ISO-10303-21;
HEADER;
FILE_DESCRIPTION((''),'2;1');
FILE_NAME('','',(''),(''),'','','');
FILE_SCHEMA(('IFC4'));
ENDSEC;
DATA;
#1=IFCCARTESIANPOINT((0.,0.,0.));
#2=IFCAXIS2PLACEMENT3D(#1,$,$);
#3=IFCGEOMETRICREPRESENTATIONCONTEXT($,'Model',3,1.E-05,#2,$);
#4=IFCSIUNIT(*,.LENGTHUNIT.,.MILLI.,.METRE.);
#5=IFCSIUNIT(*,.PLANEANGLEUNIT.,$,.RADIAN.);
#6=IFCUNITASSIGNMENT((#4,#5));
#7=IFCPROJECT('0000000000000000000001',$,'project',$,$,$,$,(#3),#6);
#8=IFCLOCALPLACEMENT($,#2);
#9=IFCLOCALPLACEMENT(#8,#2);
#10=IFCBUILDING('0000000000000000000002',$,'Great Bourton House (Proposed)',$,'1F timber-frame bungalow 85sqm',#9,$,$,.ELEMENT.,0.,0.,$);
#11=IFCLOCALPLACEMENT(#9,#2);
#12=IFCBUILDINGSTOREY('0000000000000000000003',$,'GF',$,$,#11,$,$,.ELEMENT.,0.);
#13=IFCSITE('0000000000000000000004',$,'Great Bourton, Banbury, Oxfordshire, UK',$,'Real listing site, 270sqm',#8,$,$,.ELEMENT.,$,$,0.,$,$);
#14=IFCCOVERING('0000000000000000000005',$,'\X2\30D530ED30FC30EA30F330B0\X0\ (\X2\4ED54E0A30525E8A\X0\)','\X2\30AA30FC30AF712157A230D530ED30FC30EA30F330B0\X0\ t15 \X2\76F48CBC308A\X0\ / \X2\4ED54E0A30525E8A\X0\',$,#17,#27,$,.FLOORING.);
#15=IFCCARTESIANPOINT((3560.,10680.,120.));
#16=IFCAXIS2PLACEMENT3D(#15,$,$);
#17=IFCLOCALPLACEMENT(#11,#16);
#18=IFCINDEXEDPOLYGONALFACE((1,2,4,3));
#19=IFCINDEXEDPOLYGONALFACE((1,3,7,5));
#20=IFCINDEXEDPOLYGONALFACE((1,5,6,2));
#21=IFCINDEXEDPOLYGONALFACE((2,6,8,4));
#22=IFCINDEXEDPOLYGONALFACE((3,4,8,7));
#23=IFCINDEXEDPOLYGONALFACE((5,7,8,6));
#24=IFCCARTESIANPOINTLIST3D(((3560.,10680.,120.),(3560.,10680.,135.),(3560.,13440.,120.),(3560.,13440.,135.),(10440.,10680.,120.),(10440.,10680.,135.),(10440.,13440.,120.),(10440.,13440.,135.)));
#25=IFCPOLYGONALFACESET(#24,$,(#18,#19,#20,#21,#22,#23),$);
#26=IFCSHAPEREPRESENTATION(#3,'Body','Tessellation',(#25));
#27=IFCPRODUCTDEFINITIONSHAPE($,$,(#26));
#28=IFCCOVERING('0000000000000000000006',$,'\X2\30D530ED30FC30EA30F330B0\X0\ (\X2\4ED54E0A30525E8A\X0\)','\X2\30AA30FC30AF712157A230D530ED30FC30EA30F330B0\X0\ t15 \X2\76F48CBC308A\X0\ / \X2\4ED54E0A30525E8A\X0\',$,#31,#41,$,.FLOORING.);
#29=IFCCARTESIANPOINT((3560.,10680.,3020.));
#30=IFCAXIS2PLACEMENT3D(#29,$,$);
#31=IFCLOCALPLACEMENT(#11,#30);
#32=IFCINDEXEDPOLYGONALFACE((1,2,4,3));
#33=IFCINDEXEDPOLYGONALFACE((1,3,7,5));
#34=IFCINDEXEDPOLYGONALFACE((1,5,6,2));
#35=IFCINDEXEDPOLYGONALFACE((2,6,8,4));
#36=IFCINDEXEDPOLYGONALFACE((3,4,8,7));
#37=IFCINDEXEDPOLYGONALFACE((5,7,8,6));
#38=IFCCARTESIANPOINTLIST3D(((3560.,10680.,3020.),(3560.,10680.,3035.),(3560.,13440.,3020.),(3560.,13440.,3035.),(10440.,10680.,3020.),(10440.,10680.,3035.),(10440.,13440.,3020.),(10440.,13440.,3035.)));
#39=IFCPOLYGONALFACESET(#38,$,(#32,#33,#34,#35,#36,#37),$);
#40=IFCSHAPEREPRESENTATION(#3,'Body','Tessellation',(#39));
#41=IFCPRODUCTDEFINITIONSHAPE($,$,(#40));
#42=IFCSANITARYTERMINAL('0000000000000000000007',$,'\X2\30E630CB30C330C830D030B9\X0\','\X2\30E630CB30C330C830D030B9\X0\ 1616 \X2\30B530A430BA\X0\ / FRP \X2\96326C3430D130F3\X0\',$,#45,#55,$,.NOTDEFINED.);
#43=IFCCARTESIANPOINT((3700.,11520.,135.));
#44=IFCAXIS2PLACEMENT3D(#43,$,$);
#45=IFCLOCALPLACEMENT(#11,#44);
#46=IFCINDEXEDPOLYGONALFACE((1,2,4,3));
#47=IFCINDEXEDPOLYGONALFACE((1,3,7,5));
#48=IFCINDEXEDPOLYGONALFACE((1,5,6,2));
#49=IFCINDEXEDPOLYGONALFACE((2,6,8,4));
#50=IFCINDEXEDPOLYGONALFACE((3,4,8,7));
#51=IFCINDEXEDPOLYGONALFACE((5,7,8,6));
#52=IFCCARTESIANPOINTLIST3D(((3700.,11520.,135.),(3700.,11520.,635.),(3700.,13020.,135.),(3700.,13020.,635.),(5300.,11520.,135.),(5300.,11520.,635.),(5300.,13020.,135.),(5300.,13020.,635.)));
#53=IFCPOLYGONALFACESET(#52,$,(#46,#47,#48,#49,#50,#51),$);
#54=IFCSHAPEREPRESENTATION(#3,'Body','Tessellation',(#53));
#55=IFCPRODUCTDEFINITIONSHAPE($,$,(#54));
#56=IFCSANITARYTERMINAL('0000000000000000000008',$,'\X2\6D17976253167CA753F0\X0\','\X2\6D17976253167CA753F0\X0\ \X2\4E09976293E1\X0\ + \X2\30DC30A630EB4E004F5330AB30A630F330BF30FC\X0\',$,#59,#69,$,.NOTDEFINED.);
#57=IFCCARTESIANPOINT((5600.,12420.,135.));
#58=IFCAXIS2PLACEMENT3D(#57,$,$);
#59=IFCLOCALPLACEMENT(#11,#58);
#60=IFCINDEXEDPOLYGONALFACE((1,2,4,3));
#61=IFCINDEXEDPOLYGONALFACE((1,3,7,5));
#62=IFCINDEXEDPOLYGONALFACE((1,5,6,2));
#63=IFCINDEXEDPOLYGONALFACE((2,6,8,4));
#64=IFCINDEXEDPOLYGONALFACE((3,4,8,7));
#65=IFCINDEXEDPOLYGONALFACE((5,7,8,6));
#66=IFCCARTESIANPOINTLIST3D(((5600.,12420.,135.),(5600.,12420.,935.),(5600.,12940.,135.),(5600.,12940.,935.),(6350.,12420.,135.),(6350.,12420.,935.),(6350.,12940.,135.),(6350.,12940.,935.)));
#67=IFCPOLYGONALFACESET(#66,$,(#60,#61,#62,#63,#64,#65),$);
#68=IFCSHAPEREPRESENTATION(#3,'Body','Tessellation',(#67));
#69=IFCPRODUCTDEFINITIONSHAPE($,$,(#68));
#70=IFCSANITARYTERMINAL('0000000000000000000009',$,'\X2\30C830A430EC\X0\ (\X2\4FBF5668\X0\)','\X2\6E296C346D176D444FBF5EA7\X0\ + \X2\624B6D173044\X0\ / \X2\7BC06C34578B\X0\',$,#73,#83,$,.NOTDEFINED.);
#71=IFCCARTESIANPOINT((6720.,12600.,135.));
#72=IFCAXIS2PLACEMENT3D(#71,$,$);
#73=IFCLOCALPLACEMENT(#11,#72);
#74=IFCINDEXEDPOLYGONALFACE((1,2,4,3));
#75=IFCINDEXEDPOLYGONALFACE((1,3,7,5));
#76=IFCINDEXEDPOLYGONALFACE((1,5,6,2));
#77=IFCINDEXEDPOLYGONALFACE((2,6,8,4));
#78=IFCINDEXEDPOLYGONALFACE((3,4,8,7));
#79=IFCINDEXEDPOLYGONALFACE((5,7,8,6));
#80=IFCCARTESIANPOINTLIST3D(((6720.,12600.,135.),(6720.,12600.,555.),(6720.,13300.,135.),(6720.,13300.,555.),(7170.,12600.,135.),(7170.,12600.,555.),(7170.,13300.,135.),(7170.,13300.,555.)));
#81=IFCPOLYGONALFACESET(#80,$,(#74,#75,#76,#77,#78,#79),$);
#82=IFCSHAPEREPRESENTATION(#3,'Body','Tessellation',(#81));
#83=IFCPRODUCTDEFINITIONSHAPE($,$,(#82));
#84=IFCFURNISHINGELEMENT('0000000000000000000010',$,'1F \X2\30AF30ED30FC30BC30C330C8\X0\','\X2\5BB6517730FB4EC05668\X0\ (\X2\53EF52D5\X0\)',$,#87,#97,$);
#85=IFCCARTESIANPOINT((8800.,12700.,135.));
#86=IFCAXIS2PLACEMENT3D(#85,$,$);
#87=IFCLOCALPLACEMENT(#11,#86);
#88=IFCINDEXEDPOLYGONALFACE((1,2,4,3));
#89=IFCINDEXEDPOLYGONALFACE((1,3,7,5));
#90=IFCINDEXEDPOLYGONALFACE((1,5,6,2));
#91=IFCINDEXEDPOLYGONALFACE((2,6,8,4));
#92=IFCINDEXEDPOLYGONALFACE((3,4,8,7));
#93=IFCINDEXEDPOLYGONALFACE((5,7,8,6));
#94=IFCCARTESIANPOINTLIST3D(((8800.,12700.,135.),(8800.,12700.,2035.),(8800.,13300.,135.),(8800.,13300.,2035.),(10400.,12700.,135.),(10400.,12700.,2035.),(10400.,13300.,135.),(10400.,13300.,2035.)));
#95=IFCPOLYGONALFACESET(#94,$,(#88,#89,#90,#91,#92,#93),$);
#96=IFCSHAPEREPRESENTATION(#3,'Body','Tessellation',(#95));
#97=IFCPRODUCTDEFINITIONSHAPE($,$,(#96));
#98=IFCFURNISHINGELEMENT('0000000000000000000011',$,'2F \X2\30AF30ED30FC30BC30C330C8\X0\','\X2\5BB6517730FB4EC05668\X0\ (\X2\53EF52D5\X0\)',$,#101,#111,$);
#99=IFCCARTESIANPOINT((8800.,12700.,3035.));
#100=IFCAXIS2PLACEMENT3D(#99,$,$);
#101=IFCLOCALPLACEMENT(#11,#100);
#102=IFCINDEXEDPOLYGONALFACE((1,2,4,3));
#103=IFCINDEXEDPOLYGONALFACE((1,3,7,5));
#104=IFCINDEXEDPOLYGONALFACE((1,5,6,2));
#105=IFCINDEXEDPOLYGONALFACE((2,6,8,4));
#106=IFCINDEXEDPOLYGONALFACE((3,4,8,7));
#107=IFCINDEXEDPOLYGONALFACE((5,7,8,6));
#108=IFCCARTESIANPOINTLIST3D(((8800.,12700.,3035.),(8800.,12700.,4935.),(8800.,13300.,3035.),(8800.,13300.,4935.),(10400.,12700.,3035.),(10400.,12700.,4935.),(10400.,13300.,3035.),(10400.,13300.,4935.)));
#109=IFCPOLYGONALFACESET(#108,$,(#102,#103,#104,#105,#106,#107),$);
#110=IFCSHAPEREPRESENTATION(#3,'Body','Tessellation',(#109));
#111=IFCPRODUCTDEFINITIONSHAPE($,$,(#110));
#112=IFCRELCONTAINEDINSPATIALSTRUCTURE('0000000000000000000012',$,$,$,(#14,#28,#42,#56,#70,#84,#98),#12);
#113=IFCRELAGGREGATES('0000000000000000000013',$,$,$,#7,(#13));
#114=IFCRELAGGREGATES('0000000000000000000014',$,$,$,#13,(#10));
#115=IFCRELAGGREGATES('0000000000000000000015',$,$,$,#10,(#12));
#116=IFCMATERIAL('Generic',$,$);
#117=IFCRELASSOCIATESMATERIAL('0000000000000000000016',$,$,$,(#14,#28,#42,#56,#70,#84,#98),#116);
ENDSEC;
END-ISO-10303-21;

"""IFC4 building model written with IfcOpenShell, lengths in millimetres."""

from ifc_helpers import new_model, si_unit, frame, frame_2d, origin, place, context, project, spatial, rectangle, extrude, material, element, save


model = new_model("IFC4")

# Units and contexts
model_context = context("Model", 3, precision=1e-05, world=origin())
ifc_project = project(units=[si_unit("LENGTHUNIT", "METRE", prefix="MILLI"), si_unit("PLANEANGLEUNIT", "RADIAN")], contexts=[model_context])

# Site, building, storey
site_placement = place(None, origin())
site = spatial("IfcSite", under=ifc_project, at=site_placement, Name="Great Bourton, Banbury, Oxfordshire, UK", ObjectType="Real listing site, 270sqm", CompositionType="ELEMENT", RefElevation=0.0)
building_placement = place(site_placement, origin())
building = spatial("IfcBuilding", under=site, at=building_placement, Name="Great Bourton House (Proposed)", ObjectType="1F timber-frame bungalow 85sqm", CompositionType="ELEMENT", ElevationOfRefHeight=0.0, ElevationOfTerrain=0.0)
storey_placement = place(building_placement, origin())
storey = spatial("IfcBuildingStorey", under=building, at=storey_placement, Name="GF", CompositionType="ELEMENT", Elevation=0.0)

# Coverings
ifc_material_1 = material(Name="Generic")
covering_1_placement = place(storey_placement, frame((3560.0, 10680.0, 120.0)))
element("IfcCovering", 1, at=covering_1_placement, inside=storey, material=ifc_material_1, Name="フローリング (仕上げ床)", Description="オーク無垢フローリング t15 直貼り / 仕上げ床", PredefinedType="FLOORING", context=model_context, shape_type="SweptSolid", body=[
    extrude(rectangle(XDim=6880.0, YDim=2760.0, at=frame_2d((3440.0, 1380.0))), frame((3560.0, 10680.0, 120.0)), (0.0, 0.0, 1.0), 15.0),
])
covering_2_placement = place(storey_placement, frame((3560.0, 10680.0, 3020.0)))
element("IfcCovering", 2, at=covering_2_placement, inside=storey, material=ifc_material_1, Name="フローリング (仕上げ床)", Description="オーク無垢フローリング t15 直貼り / 仕上げ床", PredefinedType="FLOORING", context=model_context, shape_type="SweptSolid", body=[
    extrude(rectangle(XDim=6880.0, YDim=2760.0, at=frame_2d((3440.0, 1380.0))), frame((3560.0, 10680.0, 3020.0)), (0.0, 0.0, 1.0), 15.0),
])

# Sanitary terminals
sanitary_terminal_1_placement = place(storey_placement, frame((3700.0, 11520.0, 135.0)))
element("IfcSanitaryTerminal", 3, at=sanitary_terminal_1_placement, inside=storey, material=ifc_material_1, Name="ユニットバス", Description="ユニットバス 1616 サイズ / FRP 防水パン", PredefinedType="NOTDEFINED", context=model_context, shape_type="SweptSolid", body=[
    extrude(rectangle(XDim=1600.0, YDim=1500.0, at=frame_2d((800.0, 750.0))), frame((3700.0, 11520.0, 135.0)), (0.0, 0.0, 1.0), 500.0),
])
sanitary_terminal_2_placement = place(storey_placement, frame((5600.0, 12420.0, 135.0)))
element("IfcSanitaryTerminal", 4, at=sanitary_terminal_2_placement, inside=storey, material=ifc_material_1, Name="洗面化粧台", Description="洗面化粧台 三面鏡 + ボウル一体カウンター", PredefinedType="NOTDEFINED", context=model_context, shape_type="SweptSolid", body=[
    extrude(rectangle(XDim=750.0, YDim=520.0, at=frame_2d((375.0, 260.0))), frame((5600.0, 12420.0, 135.0)), (0.0, 0.0, 1.0), 800.0),
])
sanitary_terminal_3_placement = place(storey_placement, frame((6720.0, 12600.0, 135.0)))
element("IfcSanitaryTerminal", 5, at=sanitary_terminal_3_placement, inside=storey, material=ifc_material_1, Name="トイレ (便器)", Description="温水洗浄便座 + 手洗い / 節水型", PredefinedType="NOTDEFINED", context=model_context, shape_type="SweptSolid", body=[
    extrude(rectangle(XDim=450.0, YDim=700.0, at=frame_2d((225.0, 350.0))), frame((6720.0, 12600.0, 135.0)), (0.0, 0.0, 1.0), 420.0),
])

# Furnishing elements
furnishing_1_placement = place(storey_placement, frame((8800.0, 12700.0, 135.0)))
element("IfcFurnishingElement", 6, at=furnishing_1_placement, inside=storey, material=ifc_material_1, Name="1F クローゼット", Description="家具・什器 (可動)", context=model_context, shape_type="SweptSolid", body=[
    extrude(rectangle(XDim=1600.0, YDim=600.0, at=frame_2d((800.0, 300.0))), frame((8800.0, 12700.0, 135.0)), (0.0, 0.0, 1.0), 1900.0),
])
furnishing_2_placement = place(storey_placement, frame((8800.0, 12700.0, 3035.0)))
element("IfcFurnishingElement", 7, at=furnishing_2_placement, inside=storey, material=ifc_material_1, Name="2F クローゼット", Description="家具・什器 (可動)", context=model_context, shape_type="SweptSolid", body=[
    extrude(rectangle(XDim=1600.0, YDim=600.0, at=frame_2d((800.0, 300.0))), frame((8800.0, 12700.0, 3035.0)), (0.0, 0.0, 1.0), 1900.0),
])

save(model, "model.ifc")
